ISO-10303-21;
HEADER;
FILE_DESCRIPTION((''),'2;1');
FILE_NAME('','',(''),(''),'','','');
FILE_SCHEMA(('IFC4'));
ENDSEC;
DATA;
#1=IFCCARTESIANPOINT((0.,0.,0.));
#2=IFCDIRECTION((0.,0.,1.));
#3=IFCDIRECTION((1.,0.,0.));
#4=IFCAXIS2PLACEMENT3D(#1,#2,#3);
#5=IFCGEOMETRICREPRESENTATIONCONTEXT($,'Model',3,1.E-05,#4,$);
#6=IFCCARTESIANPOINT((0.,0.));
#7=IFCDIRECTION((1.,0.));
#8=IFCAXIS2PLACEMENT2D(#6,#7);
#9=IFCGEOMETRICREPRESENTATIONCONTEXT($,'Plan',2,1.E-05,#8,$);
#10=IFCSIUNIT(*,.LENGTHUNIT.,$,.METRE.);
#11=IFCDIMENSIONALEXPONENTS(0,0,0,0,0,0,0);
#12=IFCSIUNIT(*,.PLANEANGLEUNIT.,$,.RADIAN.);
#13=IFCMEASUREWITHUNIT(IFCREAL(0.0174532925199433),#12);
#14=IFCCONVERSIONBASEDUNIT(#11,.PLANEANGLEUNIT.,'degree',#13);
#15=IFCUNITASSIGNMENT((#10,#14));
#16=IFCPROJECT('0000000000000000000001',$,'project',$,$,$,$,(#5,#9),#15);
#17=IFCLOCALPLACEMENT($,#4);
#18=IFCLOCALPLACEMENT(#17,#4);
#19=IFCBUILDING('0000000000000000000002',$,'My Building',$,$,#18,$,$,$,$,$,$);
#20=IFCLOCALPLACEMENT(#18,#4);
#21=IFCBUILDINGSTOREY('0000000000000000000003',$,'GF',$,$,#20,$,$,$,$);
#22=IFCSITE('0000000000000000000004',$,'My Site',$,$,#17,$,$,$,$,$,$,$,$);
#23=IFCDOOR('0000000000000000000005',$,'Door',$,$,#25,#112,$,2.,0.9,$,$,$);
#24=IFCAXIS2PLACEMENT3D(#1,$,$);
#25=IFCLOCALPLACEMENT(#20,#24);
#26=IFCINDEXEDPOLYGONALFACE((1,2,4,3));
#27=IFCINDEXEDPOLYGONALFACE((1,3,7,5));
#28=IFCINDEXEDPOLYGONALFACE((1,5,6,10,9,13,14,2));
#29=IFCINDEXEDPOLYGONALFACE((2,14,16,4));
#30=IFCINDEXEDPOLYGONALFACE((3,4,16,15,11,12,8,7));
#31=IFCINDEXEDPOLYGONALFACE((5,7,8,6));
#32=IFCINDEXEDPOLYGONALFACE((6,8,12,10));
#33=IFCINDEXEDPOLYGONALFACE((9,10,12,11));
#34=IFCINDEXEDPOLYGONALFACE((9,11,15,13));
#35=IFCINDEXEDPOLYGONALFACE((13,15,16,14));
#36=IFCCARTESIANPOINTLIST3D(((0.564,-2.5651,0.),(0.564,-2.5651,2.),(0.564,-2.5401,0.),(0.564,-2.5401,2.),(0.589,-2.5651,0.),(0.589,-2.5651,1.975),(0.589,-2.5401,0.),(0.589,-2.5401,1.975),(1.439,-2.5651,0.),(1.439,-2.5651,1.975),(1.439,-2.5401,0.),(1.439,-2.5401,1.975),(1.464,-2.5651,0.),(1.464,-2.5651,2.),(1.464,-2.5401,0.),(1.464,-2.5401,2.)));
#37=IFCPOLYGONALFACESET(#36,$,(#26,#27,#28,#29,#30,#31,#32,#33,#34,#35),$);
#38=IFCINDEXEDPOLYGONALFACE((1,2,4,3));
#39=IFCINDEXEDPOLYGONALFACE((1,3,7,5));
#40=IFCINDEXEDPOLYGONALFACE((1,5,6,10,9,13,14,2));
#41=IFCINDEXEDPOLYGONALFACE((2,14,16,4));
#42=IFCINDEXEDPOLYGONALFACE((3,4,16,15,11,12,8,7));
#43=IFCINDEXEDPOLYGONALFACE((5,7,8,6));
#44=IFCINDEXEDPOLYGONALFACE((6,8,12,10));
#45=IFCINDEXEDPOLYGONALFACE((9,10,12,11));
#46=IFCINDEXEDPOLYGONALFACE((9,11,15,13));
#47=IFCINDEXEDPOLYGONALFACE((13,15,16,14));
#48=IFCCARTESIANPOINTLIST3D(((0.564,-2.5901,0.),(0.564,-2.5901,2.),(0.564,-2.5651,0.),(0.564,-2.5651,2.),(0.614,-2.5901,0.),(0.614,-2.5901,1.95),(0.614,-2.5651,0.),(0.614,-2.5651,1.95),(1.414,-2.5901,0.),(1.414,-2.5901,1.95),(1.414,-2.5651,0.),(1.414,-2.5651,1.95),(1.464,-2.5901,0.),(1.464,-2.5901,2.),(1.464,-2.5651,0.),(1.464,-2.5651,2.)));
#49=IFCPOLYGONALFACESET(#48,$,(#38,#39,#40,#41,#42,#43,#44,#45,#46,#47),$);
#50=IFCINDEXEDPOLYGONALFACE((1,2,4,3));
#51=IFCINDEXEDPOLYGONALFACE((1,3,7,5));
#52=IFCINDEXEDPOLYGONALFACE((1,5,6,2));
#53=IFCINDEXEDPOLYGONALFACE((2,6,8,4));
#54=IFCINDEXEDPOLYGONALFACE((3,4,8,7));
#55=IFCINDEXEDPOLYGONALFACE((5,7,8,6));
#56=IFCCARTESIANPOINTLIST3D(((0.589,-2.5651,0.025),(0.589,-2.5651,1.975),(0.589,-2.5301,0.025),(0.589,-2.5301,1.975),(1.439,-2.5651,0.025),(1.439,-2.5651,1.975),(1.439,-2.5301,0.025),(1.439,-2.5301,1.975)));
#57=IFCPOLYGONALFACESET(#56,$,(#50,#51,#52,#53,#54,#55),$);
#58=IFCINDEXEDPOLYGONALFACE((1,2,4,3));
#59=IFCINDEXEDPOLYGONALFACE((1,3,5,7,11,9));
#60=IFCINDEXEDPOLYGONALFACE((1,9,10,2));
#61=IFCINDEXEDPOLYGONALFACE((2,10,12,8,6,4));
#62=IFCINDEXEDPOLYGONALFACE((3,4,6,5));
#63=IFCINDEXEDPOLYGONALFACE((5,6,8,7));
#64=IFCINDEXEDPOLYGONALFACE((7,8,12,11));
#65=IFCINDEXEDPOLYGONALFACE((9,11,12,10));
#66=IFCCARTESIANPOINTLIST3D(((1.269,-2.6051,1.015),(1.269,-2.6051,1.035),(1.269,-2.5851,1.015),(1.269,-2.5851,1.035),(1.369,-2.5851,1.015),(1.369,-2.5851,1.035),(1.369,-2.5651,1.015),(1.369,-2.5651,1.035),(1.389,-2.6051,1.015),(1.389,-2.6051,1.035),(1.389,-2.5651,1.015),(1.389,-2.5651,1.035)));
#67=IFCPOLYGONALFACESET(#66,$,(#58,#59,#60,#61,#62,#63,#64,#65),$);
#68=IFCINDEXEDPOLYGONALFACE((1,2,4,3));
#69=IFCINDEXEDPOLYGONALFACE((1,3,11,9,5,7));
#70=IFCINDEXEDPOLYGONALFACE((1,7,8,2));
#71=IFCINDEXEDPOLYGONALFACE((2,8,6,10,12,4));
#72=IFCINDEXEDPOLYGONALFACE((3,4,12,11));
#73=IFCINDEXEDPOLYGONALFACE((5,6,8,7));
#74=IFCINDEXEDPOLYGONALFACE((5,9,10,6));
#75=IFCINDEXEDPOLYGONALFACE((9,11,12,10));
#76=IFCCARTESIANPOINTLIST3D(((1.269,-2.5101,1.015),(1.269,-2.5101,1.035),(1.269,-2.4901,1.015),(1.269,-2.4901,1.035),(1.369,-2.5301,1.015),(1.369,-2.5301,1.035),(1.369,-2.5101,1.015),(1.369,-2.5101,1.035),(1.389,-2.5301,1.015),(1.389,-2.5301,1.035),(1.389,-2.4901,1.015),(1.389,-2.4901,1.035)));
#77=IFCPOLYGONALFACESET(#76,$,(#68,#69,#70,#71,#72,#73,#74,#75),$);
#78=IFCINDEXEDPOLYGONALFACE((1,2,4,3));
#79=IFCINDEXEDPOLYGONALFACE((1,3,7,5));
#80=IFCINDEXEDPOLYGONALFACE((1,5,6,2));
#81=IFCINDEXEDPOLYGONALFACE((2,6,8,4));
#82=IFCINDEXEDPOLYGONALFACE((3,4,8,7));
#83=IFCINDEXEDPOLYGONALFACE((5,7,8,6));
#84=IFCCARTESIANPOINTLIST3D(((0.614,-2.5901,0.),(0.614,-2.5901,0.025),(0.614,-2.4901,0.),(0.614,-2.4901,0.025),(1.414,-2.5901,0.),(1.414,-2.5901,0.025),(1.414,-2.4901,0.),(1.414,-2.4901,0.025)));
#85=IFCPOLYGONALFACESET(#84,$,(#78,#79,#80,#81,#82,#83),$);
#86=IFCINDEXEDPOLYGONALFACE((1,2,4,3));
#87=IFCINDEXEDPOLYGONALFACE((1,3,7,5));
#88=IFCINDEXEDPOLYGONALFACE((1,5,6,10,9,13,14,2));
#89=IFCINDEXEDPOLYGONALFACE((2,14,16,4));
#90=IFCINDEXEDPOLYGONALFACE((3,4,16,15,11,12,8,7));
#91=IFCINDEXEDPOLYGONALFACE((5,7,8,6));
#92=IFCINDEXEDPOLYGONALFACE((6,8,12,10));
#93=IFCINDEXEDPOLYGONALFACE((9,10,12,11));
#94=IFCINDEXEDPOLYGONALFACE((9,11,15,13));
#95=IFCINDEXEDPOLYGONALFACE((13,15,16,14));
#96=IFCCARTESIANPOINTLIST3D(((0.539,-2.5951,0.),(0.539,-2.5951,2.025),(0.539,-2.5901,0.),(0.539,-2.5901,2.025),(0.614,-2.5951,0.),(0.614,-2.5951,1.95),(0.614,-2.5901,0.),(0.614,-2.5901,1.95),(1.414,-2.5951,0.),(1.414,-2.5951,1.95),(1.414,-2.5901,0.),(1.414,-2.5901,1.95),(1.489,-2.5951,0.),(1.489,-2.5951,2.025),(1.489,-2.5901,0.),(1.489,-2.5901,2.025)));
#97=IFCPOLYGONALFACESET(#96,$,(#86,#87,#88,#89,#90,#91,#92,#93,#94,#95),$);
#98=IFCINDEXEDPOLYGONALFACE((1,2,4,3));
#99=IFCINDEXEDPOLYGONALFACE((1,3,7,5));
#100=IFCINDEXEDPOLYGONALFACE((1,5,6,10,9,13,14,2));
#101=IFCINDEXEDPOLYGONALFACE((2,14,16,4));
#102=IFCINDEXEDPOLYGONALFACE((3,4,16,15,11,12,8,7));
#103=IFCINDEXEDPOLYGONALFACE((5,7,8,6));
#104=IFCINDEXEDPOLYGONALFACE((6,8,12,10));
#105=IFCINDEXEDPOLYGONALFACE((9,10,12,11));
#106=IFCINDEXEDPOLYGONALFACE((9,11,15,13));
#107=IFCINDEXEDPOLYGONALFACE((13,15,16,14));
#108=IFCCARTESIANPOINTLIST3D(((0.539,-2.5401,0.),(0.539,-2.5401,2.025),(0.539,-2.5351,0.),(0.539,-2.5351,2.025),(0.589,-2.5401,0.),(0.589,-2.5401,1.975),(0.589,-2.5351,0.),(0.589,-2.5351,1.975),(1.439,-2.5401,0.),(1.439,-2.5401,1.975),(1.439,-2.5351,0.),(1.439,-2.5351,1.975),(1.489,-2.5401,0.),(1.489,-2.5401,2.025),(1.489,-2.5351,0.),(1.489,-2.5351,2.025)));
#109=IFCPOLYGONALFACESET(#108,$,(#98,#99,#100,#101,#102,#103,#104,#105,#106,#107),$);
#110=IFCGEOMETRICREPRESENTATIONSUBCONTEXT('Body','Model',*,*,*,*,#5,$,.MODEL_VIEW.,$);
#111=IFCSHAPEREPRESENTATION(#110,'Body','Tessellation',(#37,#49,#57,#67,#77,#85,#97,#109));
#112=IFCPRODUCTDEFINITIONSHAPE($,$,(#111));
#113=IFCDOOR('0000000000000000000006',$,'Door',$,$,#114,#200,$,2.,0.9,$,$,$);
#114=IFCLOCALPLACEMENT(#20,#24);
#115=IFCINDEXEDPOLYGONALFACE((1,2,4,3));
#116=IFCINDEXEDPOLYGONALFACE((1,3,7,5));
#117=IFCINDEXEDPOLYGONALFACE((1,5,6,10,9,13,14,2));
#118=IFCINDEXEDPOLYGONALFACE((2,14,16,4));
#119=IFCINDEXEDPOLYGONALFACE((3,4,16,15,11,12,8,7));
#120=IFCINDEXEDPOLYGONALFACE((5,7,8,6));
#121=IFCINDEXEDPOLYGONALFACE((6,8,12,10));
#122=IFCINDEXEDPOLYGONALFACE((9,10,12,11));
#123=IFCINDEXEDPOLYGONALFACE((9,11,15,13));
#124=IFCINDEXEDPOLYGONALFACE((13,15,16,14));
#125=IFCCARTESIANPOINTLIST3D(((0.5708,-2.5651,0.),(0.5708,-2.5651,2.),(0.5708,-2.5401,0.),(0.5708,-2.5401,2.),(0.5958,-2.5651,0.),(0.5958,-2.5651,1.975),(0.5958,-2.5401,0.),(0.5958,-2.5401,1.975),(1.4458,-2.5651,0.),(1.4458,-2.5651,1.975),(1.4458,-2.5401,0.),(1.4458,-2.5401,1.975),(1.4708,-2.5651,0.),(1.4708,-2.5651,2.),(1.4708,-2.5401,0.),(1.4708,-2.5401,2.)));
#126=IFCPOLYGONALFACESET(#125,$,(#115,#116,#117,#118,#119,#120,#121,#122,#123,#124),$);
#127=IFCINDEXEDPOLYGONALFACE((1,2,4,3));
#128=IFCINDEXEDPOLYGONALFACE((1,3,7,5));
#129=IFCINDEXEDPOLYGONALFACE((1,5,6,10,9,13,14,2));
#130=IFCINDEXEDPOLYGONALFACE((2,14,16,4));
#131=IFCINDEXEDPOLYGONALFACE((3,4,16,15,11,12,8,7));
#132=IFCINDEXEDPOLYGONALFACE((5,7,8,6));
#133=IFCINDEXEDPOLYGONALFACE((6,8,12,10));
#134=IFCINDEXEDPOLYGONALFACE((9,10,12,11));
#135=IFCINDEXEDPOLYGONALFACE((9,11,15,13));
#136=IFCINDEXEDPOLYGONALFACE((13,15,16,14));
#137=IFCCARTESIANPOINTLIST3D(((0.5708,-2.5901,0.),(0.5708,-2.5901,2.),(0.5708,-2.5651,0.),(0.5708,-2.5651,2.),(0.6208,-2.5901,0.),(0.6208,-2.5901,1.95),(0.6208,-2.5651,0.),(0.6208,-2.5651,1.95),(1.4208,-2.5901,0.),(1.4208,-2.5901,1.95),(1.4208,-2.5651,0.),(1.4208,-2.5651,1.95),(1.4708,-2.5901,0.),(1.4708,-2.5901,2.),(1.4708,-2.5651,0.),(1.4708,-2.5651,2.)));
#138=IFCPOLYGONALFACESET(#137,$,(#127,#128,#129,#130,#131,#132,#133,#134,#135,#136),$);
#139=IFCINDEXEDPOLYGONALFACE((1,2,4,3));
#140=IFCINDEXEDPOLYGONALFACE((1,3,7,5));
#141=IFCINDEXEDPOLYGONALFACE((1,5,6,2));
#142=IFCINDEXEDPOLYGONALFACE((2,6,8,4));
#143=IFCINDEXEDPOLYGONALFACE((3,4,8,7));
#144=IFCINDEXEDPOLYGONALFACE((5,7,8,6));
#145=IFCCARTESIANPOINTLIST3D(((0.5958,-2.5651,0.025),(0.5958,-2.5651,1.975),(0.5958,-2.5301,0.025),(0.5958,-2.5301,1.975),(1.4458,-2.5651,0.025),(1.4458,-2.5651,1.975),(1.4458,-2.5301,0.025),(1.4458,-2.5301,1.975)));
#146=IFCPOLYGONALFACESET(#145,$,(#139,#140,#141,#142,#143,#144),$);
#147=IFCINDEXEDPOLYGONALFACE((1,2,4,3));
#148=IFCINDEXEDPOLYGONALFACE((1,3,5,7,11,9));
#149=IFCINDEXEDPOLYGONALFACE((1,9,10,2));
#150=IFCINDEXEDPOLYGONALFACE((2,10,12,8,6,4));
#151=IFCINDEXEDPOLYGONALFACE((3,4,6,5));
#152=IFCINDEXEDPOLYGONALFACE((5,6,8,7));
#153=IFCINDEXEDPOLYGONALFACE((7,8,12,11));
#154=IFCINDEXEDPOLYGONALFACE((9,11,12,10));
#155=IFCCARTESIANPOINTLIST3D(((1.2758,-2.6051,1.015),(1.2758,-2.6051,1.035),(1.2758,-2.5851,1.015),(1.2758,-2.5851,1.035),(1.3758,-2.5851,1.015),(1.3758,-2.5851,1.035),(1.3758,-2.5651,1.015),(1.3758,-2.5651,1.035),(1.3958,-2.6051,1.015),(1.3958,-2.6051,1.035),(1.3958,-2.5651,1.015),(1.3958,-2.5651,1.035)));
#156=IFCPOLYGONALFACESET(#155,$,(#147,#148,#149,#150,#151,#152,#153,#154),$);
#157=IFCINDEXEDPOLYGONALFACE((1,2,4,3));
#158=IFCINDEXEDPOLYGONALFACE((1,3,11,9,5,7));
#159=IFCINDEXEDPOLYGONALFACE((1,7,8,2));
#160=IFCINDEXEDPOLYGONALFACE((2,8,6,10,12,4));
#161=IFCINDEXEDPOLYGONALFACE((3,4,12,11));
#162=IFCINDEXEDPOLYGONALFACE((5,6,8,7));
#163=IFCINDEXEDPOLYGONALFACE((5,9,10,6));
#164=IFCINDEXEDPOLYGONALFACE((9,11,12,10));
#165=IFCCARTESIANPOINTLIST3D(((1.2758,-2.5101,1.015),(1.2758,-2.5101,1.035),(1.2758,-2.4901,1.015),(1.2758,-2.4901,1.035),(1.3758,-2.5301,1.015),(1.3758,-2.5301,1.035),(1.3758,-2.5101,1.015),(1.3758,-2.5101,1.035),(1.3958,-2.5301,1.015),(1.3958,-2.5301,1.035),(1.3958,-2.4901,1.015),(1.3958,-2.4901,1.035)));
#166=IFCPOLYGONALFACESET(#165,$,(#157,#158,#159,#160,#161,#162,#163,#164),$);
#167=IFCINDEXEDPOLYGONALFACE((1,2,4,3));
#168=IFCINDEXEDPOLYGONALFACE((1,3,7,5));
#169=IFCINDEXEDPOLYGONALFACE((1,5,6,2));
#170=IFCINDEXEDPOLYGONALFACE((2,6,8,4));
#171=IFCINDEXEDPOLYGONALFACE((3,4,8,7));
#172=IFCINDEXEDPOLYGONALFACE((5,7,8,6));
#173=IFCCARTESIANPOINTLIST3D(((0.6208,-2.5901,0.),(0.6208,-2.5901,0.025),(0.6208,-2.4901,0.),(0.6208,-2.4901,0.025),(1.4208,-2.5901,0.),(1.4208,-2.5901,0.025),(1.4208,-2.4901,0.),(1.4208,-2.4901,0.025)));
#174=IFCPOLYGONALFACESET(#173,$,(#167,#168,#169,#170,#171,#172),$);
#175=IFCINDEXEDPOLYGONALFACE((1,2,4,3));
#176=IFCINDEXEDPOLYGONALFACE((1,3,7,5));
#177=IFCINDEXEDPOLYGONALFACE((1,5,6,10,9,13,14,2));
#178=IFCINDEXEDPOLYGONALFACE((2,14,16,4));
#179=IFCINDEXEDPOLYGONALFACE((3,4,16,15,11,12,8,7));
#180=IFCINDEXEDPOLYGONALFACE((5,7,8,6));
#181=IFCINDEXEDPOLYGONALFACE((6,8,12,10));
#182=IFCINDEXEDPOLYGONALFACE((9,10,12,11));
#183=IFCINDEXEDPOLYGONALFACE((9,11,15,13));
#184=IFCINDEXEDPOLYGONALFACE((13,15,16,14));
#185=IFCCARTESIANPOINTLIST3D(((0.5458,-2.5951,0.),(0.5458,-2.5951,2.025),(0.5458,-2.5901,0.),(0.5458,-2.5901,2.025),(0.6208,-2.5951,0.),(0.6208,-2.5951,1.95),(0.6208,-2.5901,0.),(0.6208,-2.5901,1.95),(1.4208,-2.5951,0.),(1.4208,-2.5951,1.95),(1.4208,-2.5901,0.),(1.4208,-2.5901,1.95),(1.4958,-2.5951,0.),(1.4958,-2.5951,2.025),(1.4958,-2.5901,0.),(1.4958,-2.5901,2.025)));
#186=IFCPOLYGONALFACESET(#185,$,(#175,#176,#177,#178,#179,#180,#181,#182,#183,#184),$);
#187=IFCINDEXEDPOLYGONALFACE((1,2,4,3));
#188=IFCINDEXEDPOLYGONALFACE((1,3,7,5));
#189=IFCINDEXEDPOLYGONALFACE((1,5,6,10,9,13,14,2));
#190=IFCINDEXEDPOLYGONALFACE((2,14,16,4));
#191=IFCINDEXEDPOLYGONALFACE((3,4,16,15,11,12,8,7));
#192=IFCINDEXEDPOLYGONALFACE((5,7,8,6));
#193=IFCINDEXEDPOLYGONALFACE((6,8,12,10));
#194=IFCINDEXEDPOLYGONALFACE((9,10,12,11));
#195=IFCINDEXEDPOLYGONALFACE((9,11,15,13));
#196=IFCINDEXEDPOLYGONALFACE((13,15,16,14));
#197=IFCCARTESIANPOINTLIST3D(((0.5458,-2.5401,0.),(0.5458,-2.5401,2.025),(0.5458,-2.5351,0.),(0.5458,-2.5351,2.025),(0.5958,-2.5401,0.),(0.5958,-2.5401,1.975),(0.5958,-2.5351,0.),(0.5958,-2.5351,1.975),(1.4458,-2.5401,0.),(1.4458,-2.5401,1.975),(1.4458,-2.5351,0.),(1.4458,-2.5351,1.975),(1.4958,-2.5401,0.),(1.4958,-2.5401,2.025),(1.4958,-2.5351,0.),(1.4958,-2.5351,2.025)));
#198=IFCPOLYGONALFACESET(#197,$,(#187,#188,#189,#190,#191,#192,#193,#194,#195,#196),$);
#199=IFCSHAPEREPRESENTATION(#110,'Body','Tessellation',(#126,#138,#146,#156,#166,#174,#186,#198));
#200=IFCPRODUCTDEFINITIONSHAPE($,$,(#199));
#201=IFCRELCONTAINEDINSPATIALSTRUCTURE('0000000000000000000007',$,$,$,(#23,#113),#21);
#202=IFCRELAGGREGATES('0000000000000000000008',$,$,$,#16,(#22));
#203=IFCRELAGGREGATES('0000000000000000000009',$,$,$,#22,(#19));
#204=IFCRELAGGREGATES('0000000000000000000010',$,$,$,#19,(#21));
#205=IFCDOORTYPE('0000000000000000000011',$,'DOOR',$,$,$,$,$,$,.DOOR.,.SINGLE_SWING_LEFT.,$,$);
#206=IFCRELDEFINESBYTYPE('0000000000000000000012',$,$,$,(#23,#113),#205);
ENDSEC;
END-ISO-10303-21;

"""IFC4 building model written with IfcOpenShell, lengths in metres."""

from ifc_helpers import new_model, entity, si_unit, converted_unit, frame, origin_with_axes, origin_2d_with_axis, place, context, subcontext, project, spatial, line, indexed_curve, outline, extrude, shape, source, transform, mapped, type_object, type_shapes, element, save


model = new_model("IFC4")

# Units and contexts
model_context = context("Model", 3, precision=1e-05, world=origin_with_axes())
plan_context = context("Plan", 2, precision=1e-05, world=origin_2d_with_axis())
body_context_1 = subcontext(model_context, "Body", "Model", "MODEL_VIEW")
body_context_2 = subcontext(plan_context, "Body", "Plan", "PLAN_VIEW")
ifc_project = project(units=[si_unit("LENGTHUNIT", "METRE"), converted_unit("PLANEANGLEUNIT", "degree", entity("IfcReal", 0.0174532925199433), si_unit("PLANEANGLEUNIT", "RADIAN"), dimensions=[0, 0, 0, 0, 0, 0, 0])], contexts=[model_context, plan_context])

# Site, building, storey
site_placement = place(None, origin_with_axes())
site = spatial("IfcSite", under=ifc_project, at=site_placement, Name="My Site")
building_placement = place(site_placement, origin_with_axes())
building = spatial("IfcBuilding", under=site, at=building_placement, Name="My Building")
storey_placement = place(building_placement, origin_with_axes())
storey = spatial("IfcBuildingStorey", under=building, at=storey_placement, Name="GF")

# Shared definitions
door_type = type_object("IfcDoorType", Name="DOOR", OperationType="SINGLE_SWING_LEFT", PredefinedType="DOOR")
shared_shape_1 = source(origin_with_axes(), body_context_1, "Body", "SweptSolid", [
    extrude(outline(indexed_curve([(0.0, 0.0), (0.0, 2.0), (0.9, 2.0), (0.9, 0.0), (0.875, 0.0), (0.875, 1.975), (0.025, 1.975), (0.025, 0.0)], segments=[line(1, 2, 3, 4, 5, 6, 7, 8, 1)])), frame((0.0, 0.025, 0.0), z_axis=(0.0, -1.0, 0.0), x_axis=(1.0, 0.0, 0.0)), (0.0, 0.0, -1.0), 0.025),
    extrude(outline(indexed_curve([(0.0, 0.0), (0.0, 2.0), (0.9, 2.0), (0.9, 0.0), (0.85, 0.0), (0.85, 1.95), (0.05, 1.95), (0.05, 0.0)], segments=[line(1, 2, 3, 4, 5, 6, 7, 8, 1)])), frame((0.0, 0.0, 0.0), z_axis=(0.0, -1.0, 0.0), x_axis=(1.0, 0.0, 0.0)), (0.0, 0.0, -1.0), 0.025),
    extrude(outline(indexed_curve([(0.0, 0.0), (0.85, 0.0), (0.85, 0.035), (0.0, 0.035)], segments=[line(1, 2, 3, 4, 1)])), frame((0.025, 0.025, 0.025), z_axis=(0.0, 0.0, 1.0), x_axis=(1.0, 0.0, 0.0)), (0.0, 0.0, 1.0), 1.95),
    extrude(outline(indexed_curve([(0.0, 0.0), (0.0, -0.04), (-0.12, -0.04), (-0.12, -0.02), (-0.02, -0.02), (-0.02, 0.0)], segments=[line(1, 2, 3, 4, 5, 6, 1)])), frame((0.825, 0.025, 1.015), z_axis=(0.0, 0.0, 1.0), x_axis=(1.0, 0.0, 0.0)), (0.0, 0.0, 1.0), 0.02),
    extrude(outline(indexed_curve([(0.0, 0.0), (0.0, 0.04), (-0.12, 0.04), (-0.12, 0.02), (-0.02, 0.02), (-0.02, 0.0)], segments=[line(1, 2, 3, 4, 5, 6, 1)])), frame((0.825, 0.06, 1.015), z_axis=(0.0, 0.0, 1.0), x_axis=(1.0, 0.0, 0.0)), (0.0, 0.0, 1.0), 0.02),
    extrude(outline(indexed_curve([(0.0, 0.0), (0.8, 0.0), (0.8, 0.1), (0.0, 0.1)], segments=[line(1, 2, 3, 4, 1)])), frame((0.05, 0.0, 0.0), z_axis=(0.0, 0.0, 1.0), x_axis=(1.0, 0.0, 0.0)), (0.0, 0.0, 1.0), 0.025),
    extrude(outline(indexed_curve([(0.0, 0.0), (0.0, 2.025), (0.95, 2.025), (0.95, 0.0), (0.875, 0.0), (0.875, 1.95), (0.075, 1.95), (0.075, 0.0)], segments=[line(1, 2, 3, 4, 5, 6, 7, 8, 1)])), frame((-0.025, -0.005, 0.0), z_axis=(0.0, -1.0, 0.0), x_axis=(1.0, 0.0, 0.0)), (0.0, 0.0, -1.0), 0.005),
    extrude(outline(indexed_curve([(0.0, 0.0), (0.0, 2.025), (0.95, 2.025), (0.95, 0.0), (0.9, 0.0), (0.9, 1.975), (0.05, 1.975), (0.05, 0.0)], segments=[line(1, 2, 3, 4, 5, 6, 7, 8, 1)])), frame((-0.025, 0.05, 0.0), z_axis=(0.0, -1.0, 0.0), x_axis=(1.0, 0.0, 0.0)), (0.0, 0.0, -1.0), 0.005),
])
shared_shape_2 = source(origin_with_axes(), body_context_2, "Body", "Curve2D", [
    entity("IfcIndexedPolyCurve", entity("IfcCartesianPointList2D", [[0.0, 0.0], [0.0, 0.05], [0.025, 0.05], [0.025, 0.025], [0.05, 0.025], [0.05, 0.0]]), [entity("IfcLineIndex", [1, 2, 3, 4, 5, 6, 1])]),
    entity("IfcIndexedPolyCurve", entity("IfcCartesianPointList2D", [[0.9, 0.0], [0.9, 0.05], [0.875, 0.05], [0.875, 0.025], [0.85, 0.025], [0.85, 0.0]]), [entity("IfcLineIndex", [1, 2, 3, 4, 5, 6, 1])]),
    entity("IfcTrimmedCurve", entity("IfcEllipse", entity("IfcAxis2Placement2D", entity("IfcCartesianPoint", [0.06, 0.05]), entity("IfcDirection", [1.0, 0.0])), 0.815, 0.85), [entity("IfcCartesianPoint", [0.875, 0.05])], [entity("IfcCartesianPoint", [0.06, 0.9])], True, "CARTESIAN"),
    entity("IfcIndexedPolyCurve", entity("IfcCartesianPointList2D", [[0.025, 0.05], [0.06, 0.05], [0.06, 0.9], [0.025, 0.9]]), [entity("IfcLineIndex", [1, 2, 3, 4, 1])]),
])
type_shapes(door_type, [shared_shape_1, shared_shape_2])

# Doors
for number, where, z_axis, x_axis, name in (
    (1, (0.564, -2.5901, 0.0), (0.0, 0.0, 1.0), (1.0, 0.0, 0.0), "Door"),
    (2, (0.5708, -2.5901, 0.0), (0.0, 0.0, 1.0), (1.0, 0.0, 0.0), "Door"),
):
    element("IfcDoor", number, at=place(storey_placement, frame(where, z_axis=z_axis, x_axis=x_axis)), inside=storey, type_object=door_type, Name=name, OverallHeight=2.0, OverallWidth=0.9, shapes=[
        shape(body_context_1, "Body", "MappedRepresentation", [mapped(shared_shape_1, transform((0.0, 0.0, 0.0), x_axis=(1.0, 0.0, 0.0), y_axis=(0.0, 1.0, 0.0), z_axis=(0.0, 0.0, 1.0), scale=1.0))]),
        shape(body_context_2, "Body", "MappedRepresentation", [mapped(shared_shape_2, transform((0.0, 0.0, 0.0), x_axis=(1.0, 0.0, 0.0), y_axis=(0.0, 1.0, 0.0), z_axis=(0.0, 0.0, 1.0), scale=1.0))]),
    ])

save(model, "model.ifc")
